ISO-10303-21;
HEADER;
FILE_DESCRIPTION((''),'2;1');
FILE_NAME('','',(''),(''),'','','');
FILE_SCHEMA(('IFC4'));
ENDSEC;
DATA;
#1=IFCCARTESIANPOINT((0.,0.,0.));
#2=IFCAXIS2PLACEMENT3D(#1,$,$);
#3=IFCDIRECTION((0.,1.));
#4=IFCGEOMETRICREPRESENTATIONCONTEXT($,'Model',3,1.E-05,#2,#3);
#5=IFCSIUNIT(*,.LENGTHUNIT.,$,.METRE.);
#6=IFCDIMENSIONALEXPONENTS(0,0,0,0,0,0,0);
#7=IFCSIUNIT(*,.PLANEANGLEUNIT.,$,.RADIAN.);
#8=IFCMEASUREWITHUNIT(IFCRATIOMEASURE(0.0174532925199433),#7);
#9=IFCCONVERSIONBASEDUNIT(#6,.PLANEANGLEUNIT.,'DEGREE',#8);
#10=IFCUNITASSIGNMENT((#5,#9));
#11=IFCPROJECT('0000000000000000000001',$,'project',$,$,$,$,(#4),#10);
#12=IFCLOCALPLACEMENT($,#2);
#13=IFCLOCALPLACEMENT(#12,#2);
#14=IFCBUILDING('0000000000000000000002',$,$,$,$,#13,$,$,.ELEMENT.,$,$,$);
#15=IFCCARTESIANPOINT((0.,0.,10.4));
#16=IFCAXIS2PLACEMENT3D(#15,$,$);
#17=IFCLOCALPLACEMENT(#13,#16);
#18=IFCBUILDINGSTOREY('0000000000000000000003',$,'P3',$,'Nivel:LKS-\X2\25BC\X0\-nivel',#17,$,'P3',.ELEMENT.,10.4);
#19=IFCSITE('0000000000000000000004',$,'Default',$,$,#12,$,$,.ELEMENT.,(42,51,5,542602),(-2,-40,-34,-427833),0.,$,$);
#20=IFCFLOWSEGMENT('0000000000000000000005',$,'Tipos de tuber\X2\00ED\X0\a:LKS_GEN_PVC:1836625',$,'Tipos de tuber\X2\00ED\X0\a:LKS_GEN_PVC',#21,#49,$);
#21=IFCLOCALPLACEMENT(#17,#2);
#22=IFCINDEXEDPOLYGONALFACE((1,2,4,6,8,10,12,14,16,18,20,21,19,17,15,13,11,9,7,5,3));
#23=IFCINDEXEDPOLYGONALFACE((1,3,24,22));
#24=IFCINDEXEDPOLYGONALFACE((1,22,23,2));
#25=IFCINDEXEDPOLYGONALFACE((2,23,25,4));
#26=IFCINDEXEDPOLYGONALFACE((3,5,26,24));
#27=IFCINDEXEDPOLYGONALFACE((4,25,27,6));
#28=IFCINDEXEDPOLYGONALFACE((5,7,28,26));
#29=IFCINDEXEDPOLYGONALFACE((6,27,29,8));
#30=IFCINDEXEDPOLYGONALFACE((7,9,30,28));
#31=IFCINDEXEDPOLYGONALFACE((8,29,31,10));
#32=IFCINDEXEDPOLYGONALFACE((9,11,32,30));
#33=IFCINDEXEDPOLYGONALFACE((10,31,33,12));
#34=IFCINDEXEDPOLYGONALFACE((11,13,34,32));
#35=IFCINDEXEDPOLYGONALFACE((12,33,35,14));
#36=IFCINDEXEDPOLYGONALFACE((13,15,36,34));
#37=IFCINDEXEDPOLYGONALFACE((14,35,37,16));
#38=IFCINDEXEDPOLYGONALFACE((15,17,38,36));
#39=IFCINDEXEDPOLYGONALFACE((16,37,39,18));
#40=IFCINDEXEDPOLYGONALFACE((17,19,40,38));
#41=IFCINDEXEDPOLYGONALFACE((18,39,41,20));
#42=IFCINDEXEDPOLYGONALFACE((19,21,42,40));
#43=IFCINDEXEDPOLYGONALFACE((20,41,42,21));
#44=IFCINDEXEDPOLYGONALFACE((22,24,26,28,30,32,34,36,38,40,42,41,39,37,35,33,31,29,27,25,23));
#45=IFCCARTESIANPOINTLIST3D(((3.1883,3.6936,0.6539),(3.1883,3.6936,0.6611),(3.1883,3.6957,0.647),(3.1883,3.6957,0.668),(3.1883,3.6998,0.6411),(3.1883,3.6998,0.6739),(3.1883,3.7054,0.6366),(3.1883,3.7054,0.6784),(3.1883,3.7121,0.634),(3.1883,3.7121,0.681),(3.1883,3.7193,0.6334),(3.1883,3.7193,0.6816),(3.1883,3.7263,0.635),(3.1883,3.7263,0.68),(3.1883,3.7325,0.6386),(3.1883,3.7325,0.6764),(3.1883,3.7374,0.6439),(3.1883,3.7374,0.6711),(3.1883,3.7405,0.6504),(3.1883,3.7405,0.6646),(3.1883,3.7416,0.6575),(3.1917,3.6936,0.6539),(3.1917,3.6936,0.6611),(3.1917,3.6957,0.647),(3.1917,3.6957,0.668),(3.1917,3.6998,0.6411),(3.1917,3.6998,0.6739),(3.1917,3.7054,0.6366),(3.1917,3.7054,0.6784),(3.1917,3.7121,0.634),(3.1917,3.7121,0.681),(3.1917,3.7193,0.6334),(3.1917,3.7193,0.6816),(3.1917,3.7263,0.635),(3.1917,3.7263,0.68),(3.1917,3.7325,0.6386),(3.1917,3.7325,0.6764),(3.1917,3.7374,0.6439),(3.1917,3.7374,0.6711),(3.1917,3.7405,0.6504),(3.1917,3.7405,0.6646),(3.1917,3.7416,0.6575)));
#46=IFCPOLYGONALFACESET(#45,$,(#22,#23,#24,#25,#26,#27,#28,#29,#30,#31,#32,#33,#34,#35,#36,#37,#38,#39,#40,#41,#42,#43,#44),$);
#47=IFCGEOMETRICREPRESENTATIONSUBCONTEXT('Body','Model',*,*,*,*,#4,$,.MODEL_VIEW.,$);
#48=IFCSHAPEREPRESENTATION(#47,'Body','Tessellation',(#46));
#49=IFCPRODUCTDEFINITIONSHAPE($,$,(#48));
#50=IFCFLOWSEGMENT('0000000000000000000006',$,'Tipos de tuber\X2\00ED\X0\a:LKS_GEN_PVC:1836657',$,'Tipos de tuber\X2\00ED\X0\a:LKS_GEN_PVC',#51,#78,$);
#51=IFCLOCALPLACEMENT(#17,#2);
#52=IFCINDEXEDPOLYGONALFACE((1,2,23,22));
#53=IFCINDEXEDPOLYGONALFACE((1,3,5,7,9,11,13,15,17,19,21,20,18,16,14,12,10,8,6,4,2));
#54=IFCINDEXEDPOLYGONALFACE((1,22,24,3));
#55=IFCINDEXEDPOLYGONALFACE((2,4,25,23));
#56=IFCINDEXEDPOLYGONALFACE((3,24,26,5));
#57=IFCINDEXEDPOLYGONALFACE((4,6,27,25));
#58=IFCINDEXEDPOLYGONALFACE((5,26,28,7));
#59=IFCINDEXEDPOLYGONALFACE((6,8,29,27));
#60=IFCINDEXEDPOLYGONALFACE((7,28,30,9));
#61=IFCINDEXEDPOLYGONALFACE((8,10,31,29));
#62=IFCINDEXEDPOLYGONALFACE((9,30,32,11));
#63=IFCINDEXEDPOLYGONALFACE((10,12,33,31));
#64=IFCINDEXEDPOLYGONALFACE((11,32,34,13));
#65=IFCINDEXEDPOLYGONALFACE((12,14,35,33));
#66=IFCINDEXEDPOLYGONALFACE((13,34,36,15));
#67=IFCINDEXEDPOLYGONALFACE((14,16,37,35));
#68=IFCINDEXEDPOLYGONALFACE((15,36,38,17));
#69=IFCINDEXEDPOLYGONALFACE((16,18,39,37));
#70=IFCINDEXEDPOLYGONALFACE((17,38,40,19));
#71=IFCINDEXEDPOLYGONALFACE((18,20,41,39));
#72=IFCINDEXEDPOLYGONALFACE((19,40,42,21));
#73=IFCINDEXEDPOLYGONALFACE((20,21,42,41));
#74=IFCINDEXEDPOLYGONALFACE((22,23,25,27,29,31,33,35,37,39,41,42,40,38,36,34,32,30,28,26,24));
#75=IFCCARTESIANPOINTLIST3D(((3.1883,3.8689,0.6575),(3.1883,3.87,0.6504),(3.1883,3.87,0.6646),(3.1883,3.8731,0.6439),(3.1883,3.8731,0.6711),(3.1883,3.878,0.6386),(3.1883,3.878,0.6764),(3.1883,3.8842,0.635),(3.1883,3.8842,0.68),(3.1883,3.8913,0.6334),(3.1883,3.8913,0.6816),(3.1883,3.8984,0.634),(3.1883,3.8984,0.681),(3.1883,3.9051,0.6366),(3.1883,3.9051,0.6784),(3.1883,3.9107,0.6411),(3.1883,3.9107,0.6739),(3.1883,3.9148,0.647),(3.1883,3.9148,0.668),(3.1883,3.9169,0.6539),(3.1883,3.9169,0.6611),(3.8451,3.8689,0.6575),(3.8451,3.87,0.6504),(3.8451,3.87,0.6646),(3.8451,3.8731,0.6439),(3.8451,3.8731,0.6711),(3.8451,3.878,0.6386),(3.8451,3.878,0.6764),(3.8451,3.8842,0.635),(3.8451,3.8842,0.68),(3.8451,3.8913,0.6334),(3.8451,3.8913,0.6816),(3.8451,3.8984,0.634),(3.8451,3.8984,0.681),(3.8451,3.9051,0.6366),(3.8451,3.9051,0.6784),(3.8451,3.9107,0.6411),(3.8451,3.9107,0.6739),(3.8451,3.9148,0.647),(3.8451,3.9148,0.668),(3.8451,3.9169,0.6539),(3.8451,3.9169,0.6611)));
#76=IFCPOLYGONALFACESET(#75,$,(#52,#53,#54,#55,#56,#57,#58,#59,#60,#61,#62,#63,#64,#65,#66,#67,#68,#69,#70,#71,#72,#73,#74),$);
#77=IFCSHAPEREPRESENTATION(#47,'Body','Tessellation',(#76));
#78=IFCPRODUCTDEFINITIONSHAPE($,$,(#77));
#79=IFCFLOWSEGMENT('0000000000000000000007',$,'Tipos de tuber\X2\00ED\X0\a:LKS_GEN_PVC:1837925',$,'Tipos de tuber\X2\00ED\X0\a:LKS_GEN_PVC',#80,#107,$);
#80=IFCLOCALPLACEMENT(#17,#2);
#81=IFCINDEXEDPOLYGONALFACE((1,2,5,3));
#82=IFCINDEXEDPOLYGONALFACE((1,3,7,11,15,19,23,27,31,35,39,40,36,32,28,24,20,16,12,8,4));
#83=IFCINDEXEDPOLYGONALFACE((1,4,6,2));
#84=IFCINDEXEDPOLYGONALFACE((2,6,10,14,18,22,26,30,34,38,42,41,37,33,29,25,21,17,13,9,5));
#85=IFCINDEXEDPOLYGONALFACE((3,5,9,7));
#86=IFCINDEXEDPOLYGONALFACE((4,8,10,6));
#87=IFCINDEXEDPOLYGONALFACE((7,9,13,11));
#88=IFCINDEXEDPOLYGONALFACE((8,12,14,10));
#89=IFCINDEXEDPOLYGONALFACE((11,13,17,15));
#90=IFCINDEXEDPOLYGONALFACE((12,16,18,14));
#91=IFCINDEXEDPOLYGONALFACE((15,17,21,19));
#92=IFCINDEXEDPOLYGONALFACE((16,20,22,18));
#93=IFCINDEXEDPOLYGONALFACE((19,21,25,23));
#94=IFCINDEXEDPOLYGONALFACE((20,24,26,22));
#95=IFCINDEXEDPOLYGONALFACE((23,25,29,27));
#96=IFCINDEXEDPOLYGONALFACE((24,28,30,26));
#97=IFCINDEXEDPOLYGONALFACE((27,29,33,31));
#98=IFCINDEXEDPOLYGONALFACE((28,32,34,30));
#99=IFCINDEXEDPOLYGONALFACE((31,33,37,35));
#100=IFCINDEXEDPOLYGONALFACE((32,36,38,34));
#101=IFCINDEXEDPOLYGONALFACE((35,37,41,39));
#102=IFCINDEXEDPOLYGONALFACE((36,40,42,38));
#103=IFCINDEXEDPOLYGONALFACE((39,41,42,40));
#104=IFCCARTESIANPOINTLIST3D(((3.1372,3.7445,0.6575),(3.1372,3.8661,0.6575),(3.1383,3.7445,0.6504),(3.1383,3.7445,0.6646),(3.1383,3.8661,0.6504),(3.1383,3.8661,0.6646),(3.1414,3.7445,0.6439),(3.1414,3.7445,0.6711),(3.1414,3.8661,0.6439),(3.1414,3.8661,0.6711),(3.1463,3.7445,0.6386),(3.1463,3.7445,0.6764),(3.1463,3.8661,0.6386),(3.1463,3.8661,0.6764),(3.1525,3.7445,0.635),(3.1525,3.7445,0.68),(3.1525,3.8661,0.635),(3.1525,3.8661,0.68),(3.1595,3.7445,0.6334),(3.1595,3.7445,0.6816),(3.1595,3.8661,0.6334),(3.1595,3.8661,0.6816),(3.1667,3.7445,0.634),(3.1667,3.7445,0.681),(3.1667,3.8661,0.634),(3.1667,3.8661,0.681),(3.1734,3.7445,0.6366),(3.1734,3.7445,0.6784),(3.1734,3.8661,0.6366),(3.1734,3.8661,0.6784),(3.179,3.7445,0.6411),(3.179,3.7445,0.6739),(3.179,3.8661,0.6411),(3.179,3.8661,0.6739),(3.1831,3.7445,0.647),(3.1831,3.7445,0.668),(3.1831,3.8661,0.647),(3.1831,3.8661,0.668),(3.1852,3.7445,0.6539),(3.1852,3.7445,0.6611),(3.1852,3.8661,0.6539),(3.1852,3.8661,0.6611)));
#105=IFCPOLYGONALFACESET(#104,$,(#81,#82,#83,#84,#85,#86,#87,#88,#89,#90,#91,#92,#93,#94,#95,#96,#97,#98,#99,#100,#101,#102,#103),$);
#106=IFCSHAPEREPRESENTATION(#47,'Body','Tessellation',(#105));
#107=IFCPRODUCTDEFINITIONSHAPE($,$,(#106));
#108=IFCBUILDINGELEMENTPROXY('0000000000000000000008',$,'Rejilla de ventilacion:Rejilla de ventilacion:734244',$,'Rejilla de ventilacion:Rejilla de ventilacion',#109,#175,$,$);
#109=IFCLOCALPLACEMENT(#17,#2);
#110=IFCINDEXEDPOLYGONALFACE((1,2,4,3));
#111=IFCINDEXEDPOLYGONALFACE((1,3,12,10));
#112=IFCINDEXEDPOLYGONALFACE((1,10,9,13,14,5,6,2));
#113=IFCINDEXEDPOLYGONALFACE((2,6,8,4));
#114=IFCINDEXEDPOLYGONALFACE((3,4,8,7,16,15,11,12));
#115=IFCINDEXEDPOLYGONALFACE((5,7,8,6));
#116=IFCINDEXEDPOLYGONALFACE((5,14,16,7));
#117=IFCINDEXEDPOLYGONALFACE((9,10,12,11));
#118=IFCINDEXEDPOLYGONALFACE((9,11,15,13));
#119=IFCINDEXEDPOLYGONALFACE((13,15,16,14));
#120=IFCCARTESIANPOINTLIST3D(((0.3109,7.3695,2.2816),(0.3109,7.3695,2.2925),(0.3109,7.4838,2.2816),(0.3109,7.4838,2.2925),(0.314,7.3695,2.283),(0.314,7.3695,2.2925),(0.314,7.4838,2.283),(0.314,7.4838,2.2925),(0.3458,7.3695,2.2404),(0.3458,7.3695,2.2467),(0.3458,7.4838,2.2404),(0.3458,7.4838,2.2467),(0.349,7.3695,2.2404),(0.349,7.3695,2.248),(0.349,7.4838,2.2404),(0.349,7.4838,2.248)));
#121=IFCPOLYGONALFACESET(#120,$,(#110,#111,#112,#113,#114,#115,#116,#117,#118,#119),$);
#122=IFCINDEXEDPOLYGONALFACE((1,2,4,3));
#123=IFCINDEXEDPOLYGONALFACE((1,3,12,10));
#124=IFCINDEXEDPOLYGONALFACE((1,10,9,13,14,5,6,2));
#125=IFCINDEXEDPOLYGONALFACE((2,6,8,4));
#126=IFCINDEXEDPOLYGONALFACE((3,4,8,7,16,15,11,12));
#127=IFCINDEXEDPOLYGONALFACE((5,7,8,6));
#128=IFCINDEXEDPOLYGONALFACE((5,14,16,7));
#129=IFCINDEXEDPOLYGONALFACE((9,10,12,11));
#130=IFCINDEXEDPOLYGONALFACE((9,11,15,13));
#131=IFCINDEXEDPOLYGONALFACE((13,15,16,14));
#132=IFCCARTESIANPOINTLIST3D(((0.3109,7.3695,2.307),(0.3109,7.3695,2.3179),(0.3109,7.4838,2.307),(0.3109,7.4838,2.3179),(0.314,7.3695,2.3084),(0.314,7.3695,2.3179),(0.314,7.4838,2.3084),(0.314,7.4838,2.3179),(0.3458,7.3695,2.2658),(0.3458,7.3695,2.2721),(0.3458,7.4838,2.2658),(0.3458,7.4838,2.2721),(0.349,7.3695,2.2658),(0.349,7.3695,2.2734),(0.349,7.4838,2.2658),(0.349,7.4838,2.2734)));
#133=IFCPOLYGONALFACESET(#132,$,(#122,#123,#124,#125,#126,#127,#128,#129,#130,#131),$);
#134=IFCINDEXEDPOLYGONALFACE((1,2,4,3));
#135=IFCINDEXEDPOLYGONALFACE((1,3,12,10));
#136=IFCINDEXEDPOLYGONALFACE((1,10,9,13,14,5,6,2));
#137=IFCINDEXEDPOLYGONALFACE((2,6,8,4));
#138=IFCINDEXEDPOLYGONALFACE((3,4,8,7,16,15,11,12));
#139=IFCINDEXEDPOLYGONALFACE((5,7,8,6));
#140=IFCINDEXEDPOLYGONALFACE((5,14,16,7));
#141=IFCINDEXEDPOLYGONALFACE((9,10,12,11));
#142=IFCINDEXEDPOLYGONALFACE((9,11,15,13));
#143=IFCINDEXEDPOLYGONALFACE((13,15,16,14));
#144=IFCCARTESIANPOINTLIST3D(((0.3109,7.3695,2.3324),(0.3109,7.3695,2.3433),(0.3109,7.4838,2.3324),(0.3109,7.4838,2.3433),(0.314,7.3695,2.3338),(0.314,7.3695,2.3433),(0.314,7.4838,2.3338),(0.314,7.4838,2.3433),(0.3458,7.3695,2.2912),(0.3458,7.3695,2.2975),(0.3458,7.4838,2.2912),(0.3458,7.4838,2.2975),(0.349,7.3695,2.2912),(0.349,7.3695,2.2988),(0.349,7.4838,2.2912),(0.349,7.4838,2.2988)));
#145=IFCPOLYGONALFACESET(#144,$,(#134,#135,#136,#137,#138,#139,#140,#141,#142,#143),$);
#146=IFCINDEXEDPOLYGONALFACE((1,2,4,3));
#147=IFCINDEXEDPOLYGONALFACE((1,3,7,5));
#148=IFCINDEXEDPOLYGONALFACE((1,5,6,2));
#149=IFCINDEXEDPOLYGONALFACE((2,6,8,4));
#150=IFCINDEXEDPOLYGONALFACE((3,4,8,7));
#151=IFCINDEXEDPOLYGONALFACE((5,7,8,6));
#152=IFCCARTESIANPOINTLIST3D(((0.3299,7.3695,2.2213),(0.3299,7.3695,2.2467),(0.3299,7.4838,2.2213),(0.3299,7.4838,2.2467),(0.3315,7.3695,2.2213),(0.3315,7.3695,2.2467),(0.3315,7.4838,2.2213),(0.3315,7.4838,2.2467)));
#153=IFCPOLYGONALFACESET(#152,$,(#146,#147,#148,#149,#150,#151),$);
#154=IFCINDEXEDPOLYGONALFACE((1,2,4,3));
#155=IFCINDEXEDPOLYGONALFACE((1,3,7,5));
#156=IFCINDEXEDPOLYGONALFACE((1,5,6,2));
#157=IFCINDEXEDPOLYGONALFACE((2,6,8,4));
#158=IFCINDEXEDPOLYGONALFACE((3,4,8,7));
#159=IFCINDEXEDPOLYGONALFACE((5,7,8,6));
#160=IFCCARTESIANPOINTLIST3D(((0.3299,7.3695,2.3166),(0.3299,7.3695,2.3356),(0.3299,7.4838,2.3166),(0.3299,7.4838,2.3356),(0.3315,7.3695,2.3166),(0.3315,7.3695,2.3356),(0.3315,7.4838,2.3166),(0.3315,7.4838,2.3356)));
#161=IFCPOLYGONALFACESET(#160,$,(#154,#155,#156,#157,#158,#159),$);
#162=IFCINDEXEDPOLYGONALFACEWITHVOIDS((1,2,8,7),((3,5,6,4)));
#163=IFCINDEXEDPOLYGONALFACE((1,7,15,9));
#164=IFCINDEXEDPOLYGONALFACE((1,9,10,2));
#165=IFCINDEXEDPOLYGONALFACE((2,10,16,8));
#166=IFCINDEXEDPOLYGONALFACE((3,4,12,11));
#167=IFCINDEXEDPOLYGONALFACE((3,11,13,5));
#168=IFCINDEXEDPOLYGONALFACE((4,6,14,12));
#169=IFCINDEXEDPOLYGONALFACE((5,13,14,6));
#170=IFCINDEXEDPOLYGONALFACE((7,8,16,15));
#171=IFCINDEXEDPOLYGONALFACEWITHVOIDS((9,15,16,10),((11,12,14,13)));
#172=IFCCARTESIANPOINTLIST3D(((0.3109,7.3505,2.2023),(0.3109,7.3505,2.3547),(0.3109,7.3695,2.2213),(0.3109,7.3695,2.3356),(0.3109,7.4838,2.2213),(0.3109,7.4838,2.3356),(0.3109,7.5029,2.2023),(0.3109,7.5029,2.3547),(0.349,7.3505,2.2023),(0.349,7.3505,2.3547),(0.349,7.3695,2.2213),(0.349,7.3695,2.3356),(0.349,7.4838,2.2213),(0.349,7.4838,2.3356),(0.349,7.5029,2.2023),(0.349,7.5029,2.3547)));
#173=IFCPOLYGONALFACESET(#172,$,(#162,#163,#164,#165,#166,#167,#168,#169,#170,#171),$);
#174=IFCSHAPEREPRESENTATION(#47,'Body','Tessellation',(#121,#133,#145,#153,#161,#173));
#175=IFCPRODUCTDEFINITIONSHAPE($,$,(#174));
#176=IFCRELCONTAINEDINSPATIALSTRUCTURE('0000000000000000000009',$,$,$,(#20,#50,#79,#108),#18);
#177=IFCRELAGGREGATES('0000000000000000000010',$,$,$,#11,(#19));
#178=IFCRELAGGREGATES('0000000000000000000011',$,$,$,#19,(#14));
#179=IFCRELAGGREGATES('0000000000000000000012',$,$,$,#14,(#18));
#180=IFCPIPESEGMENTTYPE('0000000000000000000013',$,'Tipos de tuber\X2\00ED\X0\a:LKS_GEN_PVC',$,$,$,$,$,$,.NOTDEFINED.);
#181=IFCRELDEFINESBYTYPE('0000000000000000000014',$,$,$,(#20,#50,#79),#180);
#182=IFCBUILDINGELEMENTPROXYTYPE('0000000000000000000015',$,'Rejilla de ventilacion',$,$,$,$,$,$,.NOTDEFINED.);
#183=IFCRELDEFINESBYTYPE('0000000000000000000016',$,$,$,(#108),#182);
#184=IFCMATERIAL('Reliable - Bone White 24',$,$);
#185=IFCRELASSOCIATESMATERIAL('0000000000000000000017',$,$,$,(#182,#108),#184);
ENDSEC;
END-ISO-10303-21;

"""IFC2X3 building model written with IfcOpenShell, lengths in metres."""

from ifc_helpers import new_model, entity, si_unit, converted_unit, direction, frame, frame_2d, origin, origin_2d_with_axis, place, context, subcontext, project, spatial, polyline, rectangle, circle, outline, extrude, source, transform, mapped, material, type_object, type_shapes, element, save


model = new_model("IFC2X3")

# Units and contexts
model_context = context("Model", 3, precision=1e-05, world=origin(), true_north=direction((0.0, 1.0)))
body_context = subcontext(model_context, "Body", "Model", "MODEL_VIEW")
ifc_project = project(units=[si_unit("LENGTHUNIT", "METRE"), converted_unit("PLANEANGLEUNIT", "DEGREE", entity("IfcRatioMeasure", 0.0174532925199433), si_unit("PLANEANGLEUNIT", "RADIAN"), dimensions=[0, 0, 0, 0, 0, 0, 0])], contexts=[model_context])

# Site, building, storey
site_placement = place(None, origin())
site = spatial("IfcSite", under=ifc_project, at=site_placement, Name="Default", CompositionType="ELEMENT", RefLatitude=(42, 51, 5, 542602), RefLongitude=(-2, -40, -34, -427833), RefElevation=0.0)
building_placement = place(site_placement, origin())
building = spatial("IfcBuilding", under=site, at=building_placement, CompositionType="ELEMENT")
storey_placement = place(building_placement, frame((0.0, 0.0, 10.4)))
storey = spatial("IfcBuildingStorey", under=building, at=storey_placement, Name="P3", ObjectType="Nivel:LKS-▼-nivel", LongName="P3", CompositionType="ELEMENT", Elevation=10.4)

# Flow segments
pipe_segment_type = type_object("IfcPipeSegmentType", Name="Tipos de tubería:LKS_GEN_PVC", PredefinedType="NOTDEFINED")
flow_segment_1_placement = place(storey_placement, origin())
element("IfcFlowSegment", 1, at=flow_segment_1_placement, inside=storey, type_object=pipe_segment_type, Name="Tipos de tubería:LKS_GEN_PVC:1836625", ObjectType="Tipos de tubería:LKS_GEN_PVC", context=body_context, shape_type="SweptSolid", body=[
    extrude(circle(Radius=0.0241, at=frame_2d((0.0, 0.0), x_axis=(1.0, 0.0))), frame((3.1883, 3.7175, 0.6575), z_axis=(1.0, 0.0, 0.0), x_axis=(0.0, 1.0, 0.0)), (0.0, 0.0, 1.0), 0.0034),
])
flow_segment_2_placement = place(storey_placement, origin())
element("IfcFlowSegment", 2, at=flow_segment_2_placement, inside=storey, type_object=pipe_segment_type, Name="Tipos de tubería:LKS_GEN_PVC:1836657", ObjectType="Tipos de tubería:LKS_GEN_PVC", context=body_context, shape_type="SweptSolid", body=[
    extrude(circle(Radius=0.0241, at=origin_2d_with_axis()), frame((3.1883, 3.8931, 0.6575), z_axis=(1.0, 0.0, 0.0), x_axis=(0.0, -1.0, 0.0)), (0.0, 0.0, 1.0), 0.6568),
])
flow_segment_3_placement = place(storey_placement, origin())
element("IfcFlowSegment", 3, at=flow_segment_3_placement, inside=storey, type_object=pipe_segment_type, Name="Tipos de tubería:LKS_GEN_PVC:1837925", ObjectType="Tipos de tubería:LKS_GEN_PVC", context=body_context, shape_type="SweptSolid", body=[
    extrude(circle(Radius=0.0241, at=frame_2d((0.0, 0.0), x_axis=(1.0, 0.0))), frame((3.1613, 3.7445, 0.6575), z_axis=(0.0, 1.0, 0.0), x_axis=(-1.0, 0.0, 0.0)), (0.0, 0.0, 1.0), 0.1216),
])

# Building element proxy
ifc_material_1 = material(Name="Reliable - Bone White 24")
building_element_proxy_type_1 = type_object("IfcBuildingElementProxyType", Name="Rejilla de ventilacion", PredefinedType="NOTDEFINED", material=ifc_material_1)
shared_shape_1 = source(origin(), body_context, "Body", "SweptSolid", [
    extrude(outline(polyline([(0.0173, 0.0159), (0.0269, 0.0159), (0.0269, 0.0191), (0.016, 0.0191), (-0.0189, -0.0159), (-0.0253, -0.0159), (-0.0253, -0.019), (-0.0176, -0.019), (0.0173, 0.0159)])), frame((-0.0571, 0.1, 1.435), z_axis=(1.0, 0.0, 0.0), x_axis=(0.0, 0.0, 1.0)), (0.0, 0.0, 1.0), 0.1143),
    extrude(outline(polyline([(0.0173, 0.0159), (0.0269, 0.0159), (0.0269, 0.0191), (0.016, 0.0191), (-0.0189, -0.0159), (-0.0253, -0.0159), (-0.0253, -0.019), (-0.0176, -0.019), (0.0173, 0.0159)])), frame((-0.0571, 0.1, 1.4604), z_axis=(1.0, 0.0, 0.0), x_axis=(0.0, 0.0, 1.0)), (0.0, 0.0, 1.0), 0.1143),
    extrude(outline(polyline([(0.0173, 0.0159), (0.0269, 0.0159), (0.0269, 0.0191), (0.016, 0.0191), (-0.0189, -0.0159), (-0.0253, -0.0159), (-0.0253, -0.019), (-0.0176, -0.019), (0.0173, 0.0159)])), frame((-0.0571, 0.1, 1.4858), z_axis=(1.0, 0.0, 0.0), x_axis=(0.0, 0.0, 1.0)), (0.0, 0.0, 1.0), 0.1143),
    extrude(rectangle(XDim=0.1143, YDim=0.0016, at=frame_2d((0.0, 0.0), x_axis=(1.0, 0.0))), frame((0.0, 0.1007, 1.3906), z_axis=(0.0, 0.0, 1.0), x_axis=(-1.0, 0.0, 0.0)), (0.0, 0.0, 1.0), 0.0254),
    extrude(rectangle(XDim=0.1143, YDim=0.0016, at=frame_2d((0.0, 0.0), x_axis=(1.0, 0.0))), frame((0.0, 0.1007, 1.4859), z_axis=(0.0, 0.0, 1.0), x_axis=(-1.0, 0.0, 0.0)), (0.0, 0.0, 1.0), 0.0191),
    extrude(outline(polyline([(-0.0762, -0.0762), (0.0762, -0.0762), (0.0762, 0.0762), (-0.0762, 0.0762), (-0.0762, -0.0762)]), holes=[polyline([(-0.0572, -0.0572), (-0.0572, 0.0572), (0.0572, 0.0572), (0.0572, -0.0572), (-0.0572, -0.0572)])]), frame((0.0, 0.0809, 1.4478), z_axis=(0.0, 1.0, 0.0), x_axis=(0.0, 0.0, 1.0)), (0.0, 0.0, 1.0), 0.0381),
])
type_shapes(building_element_proxy_type_1, [shared_shape_1])
proxy_1_placement = place(storey_placement, frame((0.23, 7.4267, 0.8307), z_axis=(0.0, 0.0, 1.0), x_axis=(0.0, -1.0, 0.0)))
element("IfcBuildingElementProxy", 4, at=proxy_1_placement, inside=storey, type_object=building_element_proxy_type_1, material=ifc_material_1, Name="Rejilla de ventilacion:Rejilla de ventilacion:734244", ObjectType="Rejilla de ventilacion:Rejilla de ventilacion", context=body_context, shape_type="MappedRepresentation", body=[
    mapped(shared_shape_1, transform((0.0, 0.0, 0.0), scale=1.0)),
])

save(model, "model.ifc")
